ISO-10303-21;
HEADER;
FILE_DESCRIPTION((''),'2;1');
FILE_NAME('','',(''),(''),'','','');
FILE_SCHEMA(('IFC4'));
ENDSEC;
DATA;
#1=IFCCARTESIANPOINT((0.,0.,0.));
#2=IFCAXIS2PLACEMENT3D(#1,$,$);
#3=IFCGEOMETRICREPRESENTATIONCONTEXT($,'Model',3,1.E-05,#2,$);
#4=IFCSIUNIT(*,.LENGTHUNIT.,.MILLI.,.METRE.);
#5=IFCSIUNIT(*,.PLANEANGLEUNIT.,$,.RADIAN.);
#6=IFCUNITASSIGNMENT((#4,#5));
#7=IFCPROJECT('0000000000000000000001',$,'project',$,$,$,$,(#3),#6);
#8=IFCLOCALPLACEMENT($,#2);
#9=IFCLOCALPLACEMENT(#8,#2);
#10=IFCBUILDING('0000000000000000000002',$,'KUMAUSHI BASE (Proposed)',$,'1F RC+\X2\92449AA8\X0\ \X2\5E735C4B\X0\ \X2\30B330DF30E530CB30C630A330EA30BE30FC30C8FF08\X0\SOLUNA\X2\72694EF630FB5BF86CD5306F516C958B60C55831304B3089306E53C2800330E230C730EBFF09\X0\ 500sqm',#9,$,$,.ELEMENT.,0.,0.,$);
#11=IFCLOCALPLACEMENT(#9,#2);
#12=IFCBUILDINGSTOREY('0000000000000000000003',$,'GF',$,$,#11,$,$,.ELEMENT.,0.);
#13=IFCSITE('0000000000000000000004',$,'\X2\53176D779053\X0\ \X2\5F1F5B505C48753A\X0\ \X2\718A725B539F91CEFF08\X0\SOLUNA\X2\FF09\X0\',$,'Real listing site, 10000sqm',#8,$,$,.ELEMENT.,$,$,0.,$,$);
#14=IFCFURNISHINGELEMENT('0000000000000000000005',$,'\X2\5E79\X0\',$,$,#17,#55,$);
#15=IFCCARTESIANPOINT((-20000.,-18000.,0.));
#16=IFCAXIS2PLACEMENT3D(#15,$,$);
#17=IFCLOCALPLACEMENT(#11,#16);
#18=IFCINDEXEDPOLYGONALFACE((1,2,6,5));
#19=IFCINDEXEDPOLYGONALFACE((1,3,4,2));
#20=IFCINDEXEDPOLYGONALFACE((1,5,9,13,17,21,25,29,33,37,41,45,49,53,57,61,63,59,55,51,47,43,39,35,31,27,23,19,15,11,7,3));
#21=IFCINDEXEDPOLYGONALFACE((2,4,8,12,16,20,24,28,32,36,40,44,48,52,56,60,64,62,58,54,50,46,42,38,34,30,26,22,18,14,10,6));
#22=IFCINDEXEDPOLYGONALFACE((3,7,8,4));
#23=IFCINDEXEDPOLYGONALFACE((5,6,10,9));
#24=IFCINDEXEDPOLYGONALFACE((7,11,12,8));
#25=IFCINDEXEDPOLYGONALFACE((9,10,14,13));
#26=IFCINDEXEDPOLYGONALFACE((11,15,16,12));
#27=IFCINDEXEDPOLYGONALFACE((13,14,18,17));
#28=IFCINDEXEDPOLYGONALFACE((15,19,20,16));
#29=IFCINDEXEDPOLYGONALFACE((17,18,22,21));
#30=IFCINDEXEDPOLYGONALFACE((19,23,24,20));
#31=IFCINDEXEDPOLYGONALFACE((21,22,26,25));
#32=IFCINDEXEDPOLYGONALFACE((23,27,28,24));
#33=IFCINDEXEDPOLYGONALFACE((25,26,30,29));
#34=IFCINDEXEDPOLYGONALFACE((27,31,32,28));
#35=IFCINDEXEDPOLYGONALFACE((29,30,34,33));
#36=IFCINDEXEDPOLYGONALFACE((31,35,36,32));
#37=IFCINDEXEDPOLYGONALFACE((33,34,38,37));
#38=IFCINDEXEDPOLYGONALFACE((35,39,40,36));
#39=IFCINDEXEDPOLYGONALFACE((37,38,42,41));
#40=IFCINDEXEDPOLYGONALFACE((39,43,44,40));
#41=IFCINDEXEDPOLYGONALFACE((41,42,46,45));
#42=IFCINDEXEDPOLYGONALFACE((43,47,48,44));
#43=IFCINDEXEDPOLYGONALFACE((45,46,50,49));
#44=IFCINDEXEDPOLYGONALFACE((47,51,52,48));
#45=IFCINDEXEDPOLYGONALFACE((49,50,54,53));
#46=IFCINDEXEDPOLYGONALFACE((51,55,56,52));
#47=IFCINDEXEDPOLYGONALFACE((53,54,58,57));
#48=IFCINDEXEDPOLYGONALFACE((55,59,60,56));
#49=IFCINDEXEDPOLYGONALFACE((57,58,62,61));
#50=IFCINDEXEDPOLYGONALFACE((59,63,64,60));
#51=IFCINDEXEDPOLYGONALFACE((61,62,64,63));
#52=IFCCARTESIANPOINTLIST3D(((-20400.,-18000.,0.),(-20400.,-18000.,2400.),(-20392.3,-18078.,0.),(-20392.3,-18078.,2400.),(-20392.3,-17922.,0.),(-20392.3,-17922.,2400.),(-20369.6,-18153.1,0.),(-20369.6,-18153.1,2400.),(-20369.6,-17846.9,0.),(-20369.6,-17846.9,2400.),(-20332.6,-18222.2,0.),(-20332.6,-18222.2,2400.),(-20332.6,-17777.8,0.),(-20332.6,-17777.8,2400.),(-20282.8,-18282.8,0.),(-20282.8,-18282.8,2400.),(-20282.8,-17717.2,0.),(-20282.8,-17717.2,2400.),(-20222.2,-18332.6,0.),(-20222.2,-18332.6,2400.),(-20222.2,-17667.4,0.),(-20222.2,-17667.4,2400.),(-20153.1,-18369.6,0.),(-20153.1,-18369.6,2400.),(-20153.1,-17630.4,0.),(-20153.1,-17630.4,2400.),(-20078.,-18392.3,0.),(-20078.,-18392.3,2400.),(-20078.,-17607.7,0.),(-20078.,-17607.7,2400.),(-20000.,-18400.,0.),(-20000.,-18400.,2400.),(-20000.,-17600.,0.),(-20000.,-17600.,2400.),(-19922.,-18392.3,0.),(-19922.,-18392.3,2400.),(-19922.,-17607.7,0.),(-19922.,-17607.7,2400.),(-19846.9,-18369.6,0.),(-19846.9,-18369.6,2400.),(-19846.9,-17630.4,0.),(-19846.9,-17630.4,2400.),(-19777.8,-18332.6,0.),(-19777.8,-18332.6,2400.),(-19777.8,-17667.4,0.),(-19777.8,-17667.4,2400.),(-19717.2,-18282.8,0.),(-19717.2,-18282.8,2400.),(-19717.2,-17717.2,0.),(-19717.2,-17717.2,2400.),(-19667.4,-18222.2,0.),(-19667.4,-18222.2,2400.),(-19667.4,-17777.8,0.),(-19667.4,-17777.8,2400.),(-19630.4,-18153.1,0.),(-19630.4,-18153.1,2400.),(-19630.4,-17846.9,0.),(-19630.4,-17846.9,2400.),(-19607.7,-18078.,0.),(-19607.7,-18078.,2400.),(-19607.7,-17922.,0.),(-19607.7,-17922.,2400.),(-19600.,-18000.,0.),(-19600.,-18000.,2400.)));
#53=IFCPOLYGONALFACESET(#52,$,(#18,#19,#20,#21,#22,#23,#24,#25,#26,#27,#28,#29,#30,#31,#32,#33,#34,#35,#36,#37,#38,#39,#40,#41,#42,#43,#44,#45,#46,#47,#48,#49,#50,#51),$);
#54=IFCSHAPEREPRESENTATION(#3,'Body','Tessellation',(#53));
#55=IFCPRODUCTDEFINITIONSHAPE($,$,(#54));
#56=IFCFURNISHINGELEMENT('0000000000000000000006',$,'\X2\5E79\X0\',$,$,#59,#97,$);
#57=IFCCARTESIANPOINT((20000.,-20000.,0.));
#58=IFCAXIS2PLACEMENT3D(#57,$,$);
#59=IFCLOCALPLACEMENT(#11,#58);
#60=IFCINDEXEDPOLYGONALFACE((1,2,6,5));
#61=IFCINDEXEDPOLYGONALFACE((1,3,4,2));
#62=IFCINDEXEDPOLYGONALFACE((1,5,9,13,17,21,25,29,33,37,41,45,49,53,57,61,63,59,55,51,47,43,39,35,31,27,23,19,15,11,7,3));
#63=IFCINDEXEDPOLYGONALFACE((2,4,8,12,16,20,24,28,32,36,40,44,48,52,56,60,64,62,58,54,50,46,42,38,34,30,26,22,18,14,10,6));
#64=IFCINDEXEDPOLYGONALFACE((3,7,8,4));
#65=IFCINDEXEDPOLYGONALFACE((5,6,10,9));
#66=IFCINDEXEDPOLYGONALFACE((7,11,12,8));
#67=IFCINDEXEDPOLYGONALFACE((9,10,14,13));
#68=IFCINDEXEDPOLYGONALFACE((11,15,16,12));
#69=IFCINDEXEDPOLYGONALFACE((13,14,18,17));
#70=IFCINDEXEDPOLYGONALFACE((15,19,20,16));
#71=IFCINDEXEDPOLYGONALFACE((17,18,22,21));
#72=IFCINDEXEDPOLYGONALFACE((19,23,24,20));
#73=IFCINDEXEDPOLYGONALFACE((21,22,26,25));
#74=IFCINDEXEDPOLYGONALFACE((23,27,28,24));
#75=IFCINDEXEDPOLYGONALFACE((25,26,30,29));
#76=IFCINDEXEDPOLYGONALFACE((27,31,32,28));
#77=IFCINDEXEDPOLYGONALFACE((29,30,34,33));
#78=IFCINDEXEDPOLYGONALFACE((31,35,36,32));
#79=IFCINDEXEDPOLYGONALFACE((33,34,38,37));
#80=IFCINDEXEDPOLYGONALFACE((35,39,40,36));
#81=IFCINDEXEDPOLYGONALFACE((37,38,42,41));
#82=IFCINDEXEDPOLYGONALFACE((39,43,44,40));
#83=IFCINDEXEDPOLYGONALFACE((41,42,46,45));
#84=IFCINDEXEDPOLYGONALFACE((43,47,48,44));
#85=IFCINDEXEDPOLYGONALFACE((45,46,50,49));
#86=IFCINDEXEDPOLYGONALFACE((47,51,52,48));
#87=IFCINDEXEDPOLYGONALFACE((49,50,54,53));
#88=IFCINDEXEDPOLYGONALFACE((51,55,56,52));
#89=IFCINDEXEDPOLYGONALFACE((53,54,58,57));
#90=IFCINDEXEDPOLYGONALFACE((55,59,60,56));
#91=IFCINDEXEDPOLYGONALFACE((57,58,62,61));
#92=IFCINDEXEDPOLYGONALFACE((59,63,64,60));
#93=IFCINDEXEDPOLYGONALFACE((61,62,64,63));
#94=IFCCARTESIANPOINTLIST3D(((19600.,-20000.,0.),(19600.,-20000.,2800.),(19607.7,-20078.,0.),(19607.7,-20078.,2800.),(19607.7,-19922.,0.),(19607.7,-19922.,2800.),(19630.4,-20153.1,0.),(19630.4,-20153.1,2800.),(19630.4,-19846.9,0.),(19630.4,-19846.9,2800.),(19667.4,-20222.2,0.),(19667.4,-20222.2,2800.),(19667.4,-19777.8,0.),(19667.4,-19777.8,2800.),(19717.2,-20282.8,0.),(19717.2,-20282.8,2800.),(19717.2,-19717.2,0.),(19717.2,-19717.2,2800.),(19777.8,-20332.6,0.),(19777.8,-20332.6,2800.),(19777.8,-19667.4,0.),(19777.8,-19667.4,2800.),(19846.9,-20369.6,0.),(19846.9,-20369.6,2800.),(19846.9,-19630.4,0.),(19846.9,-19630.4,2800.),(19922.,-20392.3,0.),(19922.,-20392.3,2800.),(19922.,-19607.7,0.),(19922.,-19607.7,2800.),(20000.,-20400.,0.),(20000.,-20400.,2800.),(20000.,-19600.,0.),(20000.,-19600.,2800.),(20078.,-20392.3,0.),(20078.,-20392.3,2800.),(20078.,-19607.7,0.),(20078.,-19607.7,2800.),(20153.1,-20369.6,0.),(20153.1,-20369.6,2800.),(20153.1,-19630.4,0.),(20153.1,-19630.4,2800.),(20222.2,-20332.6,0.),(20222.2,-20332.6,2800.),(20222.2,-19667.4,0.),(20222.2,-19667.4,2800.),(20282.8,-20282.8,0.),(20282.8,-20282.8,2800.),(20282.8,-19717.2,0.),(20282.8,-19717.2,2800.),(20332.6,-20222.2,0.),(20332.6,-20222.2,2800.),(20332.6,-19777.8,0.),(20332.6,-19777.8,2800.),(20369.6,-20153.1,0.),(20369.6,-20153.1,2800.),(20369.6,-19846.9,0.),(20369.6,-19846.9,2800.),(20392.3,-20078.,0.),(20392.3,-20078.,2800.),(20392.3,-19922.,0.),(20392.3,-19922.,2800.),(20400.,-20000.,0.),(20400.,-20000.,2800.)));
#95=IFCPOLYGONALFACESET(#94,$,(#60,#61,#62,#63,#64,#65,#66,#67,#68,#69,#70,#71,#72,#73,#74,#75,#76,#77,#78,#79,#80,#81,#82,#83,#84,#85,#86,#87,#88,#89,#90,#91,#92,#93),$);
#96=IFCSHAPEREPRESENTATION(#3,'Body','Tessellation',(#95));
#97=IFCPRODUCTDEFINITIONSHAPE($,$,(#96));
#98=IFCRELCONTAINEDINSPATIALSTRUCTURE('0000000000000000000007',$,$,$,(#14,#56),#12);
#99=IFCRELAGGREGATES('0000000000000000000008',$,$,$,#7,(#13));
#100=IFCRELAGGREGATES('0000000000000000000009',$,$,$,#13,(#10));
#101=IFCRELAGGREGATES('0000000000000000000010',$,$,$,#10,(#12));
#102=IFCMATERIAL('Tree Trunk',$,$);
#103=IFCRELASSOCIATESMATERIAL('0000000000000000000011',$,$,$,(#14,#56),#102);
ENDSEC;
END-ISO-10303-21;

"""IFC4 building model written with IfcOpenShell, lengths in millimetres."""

from ifc_helpers import new_model, si_unit, frame, origin, origin_2d, place, context, project, spatial, circle, extrude, material, element, save


model = new_model("IFC4")

# Units and contexts
model_context = context("Model", 3, precision=1e-05, world=origin())
ifc_project = project(units=[si_unit("LENGTHUNIT", "METRE", prefix="MILLI"), si_unit("PLANEANGLEUNIT", "RADIAN")], contexts=[model_context])

# Site, building, storey
site_placement = place(None, origin())
site = spatial("IfcSite", under=ifc_project, at=site_placement, Name="北海道 弟子屈町 熊牛原野（SOLUNA）", ObjectType="Real listing site, 10000sqm", CompositionType="ELEMENT", RefElevation=0.0)
building_placement = place(site_placement, origin())
building = spatial("IfcBuilding", under=site, at=building_placement, Name="KUMAUSHI BASE (Proposed)", ObjectType="1F RC+鉄骨 平屋 コミュニティリゾート（SOLUNA物件・寸法は公開情報からの参考モデル） 500sqm", CompositionType="ELEMENT", ElevationOfRefHeight=0.0, ElevationOfTerrain=0.0)
storey_placement = place(building_placement, origin())
storey = spatial("IfcBuildingStorey", under=building, at=storey_placement, Name="GF", CompositionType="ELEMENT", Elevation=0.0)

# Furnishing elements
ifc_material_1 = material(Name="Tree Trunk")
furnishing_1_placement = place(storey_placement, frame((-20000.0, -18000.0, 0.0)))
element("IfcFurnishingElement", 1, at=furnishing_1_placement, inside=storey, material=ifc_material_1, Name="幹", context=model_context, shape_type="SweptSolid", body=[
    extrude(circle(Radius=400.0, at=origin_2d()), frame((-20000.0, -18000.0, 0.0)), (0.0, 0.0, 1.0), 2400.0),
])
furnishing_2_placement = place(storey_placement, frame((20000.0, -20000.0, 0.0)))
element("IfcFurnishingElement", 2, at=furnishing_2_placement, inside=storey, material=ifc_material_1, Name="幹", context=model_context, shape_type="SweptSolid", body=[
    extrude(circle(Radius=400.0, at=origin_2d()), frame((20000.0, -20000.0, 0.0)), (0.0, 0.0, 1.0), 2800.0),
])

save(model, "model.ifc")
